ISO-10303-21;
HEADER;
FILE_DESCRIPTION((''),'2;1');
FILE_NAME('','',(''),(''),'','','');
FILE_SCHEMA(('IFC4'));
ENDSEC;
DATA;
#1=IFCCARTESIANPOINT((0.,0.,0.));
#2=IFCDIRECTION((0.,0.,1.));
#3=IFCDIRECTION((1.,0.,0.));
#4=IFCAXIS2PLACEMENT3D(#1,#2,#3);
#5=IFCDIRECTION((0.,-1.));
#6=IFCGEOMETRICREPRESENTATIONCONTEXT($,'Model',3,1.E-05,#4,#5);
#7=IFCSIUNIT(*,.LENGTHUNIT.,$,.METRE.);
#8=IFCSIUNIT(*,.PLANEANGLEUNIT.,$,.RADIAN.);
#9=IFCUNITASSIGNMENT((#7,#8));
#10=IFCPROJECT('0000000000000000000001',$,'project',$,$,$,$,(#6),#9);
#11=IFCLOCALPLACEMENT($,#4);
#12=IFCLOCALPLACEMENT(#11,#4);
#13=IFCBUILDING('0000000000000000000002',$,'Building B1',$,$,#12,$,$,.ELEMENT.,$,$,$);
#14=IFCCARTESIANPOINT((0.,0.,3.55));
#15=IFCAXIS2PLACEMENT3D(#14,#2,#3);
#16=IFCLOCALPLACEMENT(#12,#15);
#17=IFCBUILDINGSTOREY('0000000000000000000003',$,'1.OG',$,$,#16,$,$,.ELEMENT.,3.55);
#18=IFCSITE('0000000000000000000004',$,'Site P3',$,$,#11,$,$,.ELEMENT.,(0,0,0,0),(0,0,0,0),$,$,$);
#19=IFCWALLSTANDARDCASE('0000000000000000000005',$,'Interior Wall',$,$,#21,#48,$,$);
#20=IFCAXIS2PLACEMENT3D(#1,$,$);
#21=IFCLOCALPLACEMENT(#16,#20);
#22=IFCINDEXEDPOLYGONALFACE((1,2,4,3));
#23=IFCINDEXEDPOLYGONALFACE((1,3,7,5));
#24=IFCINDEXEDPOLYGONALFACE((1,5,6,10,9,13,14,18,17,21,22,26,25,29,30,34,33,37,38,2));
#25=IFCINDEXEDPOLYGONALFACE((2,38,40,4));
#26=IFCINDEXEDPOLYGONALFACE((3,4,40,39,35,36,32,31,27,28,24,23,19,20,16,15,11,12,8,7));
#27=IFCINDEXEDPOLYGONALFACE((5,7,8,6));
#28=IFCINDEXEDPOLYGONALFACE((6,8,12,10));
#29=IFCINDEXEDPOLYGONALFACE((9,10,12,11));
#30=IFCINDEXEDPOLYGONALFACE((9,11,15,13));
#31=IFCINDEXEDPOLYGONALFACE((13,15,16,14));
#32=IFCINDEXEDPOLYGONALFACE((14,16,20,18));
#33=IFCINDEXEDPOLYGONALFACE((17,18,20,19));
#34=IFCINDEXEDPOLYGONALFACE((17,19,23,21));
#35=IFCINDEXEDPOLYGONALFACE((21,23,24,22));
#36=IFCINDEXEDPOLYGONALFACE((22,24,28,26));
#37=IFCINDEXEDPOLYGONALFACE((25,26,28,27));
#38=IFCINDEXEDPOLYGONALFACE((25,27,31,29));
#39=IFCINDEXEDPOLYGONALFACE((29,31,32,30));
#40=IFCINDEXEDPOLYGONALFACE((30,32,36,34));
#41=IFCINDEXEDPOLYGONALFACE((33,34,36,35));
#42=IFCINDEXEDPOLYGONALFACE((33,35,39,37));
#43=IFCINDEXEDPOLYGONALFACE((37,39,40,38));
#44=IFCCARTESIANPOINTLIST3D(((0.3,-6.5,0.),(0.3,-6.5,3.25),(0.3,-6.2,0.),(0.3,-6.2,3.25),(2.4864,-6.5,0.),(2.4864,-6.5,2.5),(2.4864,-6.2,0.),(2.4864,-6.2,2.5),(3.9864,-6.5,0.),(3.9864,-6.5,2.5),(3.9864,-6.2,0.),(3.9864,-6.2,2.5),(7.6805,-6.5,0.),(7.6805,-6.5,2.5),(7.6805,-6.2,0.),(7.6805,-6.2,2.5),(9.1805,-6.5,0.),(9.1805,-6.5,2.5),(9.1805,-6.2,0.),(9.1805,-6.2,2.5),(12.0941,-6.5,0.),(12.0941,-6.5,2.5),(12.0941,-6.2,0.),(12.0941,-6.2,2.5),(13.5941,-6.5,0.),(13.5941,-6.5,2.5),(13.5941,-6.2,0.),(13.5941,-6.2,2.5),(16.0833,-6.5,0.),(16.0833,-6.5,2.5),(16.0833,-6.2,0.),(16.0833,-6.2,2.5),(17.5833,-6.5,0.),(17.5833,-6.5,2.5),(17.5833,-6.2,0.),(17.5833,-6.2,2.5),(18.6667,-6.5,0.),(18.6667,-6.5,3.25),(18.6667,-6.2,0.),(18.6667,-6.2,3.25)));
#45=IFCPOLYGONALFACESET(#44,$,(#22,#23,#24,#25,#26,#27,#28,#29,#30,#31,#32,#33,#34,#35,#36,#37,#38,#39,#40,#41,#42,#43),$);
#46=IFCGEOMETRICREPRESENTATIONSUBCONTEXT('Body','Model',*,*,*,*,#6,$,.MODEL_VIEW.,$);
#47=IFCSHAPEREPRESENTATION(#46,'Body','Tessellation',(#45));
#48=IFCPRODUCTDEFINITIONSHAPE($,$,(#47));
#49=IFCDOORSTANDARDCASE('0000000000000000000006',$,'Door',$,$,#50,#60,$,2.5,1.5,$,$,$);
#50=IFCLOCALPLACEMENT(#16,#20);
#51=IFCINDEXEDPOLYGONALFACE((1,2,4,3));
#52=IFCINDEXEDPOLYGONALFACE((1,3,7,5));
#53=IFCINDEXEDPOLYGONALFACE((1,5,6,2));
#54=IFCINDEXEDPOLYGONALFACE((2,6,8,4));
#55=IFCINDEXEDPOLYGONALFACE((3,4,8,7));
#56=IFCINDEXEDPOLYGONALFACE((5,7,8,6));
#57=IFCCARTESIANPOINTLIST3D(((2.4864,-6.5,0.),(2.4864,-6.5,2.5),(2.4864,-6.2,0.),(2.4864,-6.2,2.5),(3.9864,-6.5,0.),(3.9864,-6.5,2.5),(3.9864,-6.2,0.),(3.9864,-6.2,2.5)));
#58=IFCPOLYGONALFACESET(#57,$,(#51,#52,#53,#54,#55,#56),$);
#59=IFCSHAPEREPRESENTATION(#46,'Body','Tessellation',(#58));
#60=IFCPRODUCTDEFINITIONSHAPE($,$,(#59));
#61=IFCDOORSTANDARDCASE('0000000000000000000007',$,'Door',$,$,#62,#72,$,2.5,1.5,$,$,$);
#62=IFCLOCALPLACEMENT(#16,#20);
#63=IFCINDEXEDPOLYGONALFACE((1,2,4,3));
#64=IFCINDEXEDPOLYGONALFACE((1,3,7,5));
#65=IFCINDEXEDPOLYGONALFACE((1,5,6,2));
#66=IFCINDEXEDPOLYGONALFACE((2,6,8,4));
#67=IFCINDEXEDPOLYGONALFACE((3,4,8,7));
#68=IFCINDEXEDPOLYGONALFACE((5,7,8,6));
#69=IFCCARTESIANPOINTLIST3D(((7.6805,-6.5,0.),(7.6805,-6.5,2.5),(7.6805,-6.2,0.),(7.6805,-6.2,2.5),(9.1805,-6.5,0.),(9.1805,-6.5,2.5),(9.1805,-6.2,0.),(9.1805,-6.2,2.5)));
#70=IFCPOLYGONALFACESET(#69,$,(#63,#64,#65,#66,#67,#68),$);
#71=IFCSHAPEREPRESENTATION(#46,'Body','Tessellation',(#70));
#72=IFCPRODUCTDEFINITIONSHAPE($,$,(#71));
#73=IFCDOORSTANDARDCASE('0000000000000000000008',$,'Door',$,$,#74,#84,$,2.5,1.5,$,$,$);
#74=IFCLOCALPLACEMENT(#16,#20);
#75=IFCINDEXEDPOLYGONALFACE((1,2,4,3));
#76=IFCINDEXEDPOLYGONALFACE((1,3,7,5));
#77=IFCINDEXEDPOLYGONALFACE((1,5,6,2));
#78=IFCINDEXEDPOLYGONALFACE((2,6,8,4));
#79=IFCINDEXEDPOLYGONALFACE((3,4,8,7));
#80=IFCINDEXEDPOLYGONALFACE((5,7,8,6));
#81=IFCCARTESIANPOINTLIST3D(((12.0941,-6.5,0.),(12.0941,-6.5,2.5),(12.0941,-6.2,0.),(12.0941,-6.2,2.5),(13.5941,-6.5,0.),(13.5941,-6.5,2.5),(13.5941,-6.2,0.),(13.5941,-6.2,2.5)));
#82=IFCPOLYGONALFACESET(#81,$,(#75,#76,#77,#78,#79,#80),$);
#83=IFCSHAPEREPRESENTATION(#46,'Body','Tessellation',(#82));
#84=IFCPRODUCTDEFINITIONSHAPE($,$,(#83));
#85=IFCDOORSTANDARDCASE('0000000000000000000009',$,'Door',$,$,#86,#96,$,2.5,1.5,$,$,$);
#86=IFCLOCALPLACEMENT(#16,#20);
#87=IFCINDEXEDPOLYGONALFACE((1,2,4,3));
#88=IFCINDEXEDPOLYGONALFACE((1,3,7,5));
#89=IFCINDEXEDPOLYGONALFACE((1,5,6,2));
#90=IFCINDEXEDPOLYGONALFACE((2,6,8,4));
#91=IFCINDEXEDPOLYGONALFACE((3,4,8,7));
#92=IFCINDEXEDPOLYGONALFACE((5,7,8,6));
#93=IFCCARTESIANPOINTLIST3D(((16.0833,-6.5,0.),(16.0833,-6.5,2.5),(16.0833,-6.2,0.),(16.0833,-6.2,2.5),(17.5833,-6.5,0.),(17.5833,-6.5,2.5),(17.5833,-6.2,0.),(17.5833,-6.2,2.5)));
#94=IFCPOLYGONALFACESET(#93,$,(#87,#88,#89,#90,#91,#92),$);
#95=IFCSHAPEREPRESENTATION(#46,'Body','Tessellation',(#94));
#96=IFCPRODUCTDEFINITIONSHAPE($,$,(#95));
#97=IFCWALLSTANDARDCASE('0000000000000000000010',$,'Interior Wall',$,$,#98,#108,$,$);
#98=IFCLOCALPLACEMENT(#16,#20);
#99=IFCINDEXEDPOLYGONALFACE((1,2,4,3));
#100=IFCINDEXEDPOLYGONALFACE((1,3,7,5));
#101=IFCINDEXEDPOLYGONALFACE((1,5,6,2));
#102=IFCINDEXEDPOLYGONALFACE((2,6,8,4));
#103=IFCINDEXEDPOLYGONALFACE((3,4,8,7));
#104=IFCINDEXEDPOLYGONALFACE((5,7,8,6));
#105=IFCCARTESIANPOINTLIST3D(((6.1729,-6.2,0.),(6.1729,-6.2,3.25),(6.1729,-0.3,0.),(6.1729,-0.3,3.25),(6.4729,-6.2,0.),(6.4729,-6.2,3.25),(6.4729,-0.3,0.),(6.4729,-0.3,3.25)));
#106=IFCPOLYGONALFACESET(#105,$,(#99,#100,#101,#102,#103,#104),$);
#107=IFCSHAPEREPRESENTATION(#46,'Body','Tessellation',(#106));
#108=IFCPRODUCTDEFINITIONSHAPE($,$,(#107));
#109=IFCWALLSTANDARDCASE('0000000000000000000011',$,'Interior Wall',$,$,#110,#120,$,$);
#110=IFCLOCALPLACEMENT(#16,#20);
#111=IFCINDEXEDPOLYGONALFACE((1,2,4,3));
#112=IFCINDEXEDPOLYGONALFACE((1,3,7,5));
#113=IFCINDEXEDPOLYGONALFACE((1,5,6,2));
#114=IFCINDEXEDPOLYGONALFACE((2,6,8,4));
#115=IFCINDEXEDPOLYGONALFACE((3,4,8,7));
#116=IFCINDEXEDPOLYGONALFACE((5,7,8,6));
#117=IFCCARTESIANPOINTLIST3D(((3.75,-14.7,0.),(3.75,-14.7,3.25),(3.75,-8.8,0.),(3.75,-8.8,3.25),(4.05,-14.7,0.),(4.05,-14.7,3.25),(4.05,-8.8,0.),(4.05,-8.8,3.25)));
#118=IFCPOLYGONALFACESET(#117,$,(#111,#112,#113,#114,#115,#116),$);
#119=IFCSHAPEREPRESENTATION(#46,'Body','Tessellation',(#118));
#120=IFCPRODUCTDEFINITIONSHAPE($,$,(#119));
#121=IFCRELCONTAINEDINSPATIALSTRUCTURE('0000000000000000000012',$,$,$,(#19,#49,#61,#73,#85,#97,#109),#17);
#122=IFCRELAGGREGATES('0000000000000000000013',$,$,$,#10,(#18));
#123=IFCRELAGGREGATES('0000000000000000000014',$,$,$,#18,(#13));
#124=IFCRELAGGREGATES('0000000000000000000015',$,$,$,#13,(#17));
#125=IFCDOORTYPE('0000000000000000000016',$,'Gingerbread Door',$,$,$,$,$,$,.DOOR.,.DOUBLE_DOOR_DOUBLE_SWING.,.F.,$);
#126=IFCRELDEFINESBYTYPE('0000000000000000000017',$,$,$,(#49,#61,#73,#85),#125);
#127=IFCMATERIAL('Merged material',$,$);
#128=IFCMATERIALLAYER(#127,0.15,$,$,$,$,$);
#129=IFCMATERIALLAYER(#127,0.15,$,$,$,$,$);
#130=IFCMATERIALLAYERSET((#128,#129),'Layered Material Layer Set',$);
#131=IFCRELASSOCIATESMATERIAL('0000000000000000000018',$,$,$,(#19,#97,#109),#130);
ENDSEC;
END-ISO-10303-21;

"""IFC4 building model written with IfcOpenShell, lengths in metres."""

from ifc_helpers import new_model, si_unit, direction, frame, origin_with_axes, place, context, subcontext, project, spatial, polyline, outline, extrude, source, transform, mapped, material, layer, layer_set, layer_usage, type_object, element, fill, save


model = new_model("IFC4")

# Units and contexts
model_context = context("Model", 3, precision=1e-05, world=origin_with_axes(), true_north=direction((0.0, -1.0)))
body_context = subcontext(model_context, "Body", "Model", "MODEL_VIEW")
ifc_project = project(units=[si_unit("LENGTHUNIT", "METRE"), si_unit("PLANEANGLEUNIT", "RADIAN")], contexts=[model_context])

# Site, building, storey
site_placement = place(None, origin_with_axes())
site = spatial("IfcSite", under=ifc_project, at=site_placement, Name="Site P3", CompositionType="ELEMENT", RefLatitude=(0, 0, 0, 0), RefLongitude=(0, 0, 0, 0))
building_placement = place(site_placement, origin_with_axes())
building = spatial("IfcBuilding", under=site, at=building_placement, Name="Building B1", CompositionType="ELEMENT")
storey_placement = place(building_placement, frame((0.0, 0.0, 3.55), z_axis=(0.0, 0.0, 1.0), x_axis=(1.0, 0.0, 0.0)))
storey = spatial("IfcBuildingStorey", under=building, at=storey_placement, Name="1.OG", CompositionType="ELEMENT", Elevation=3.55)

# Shared definitions
ifc_material = material(Name="Merged material")

# Wall, openings, doors
ifc_layer_1 = layer(ifc_material, 0.15)
ifc_layer_2 = layer(ifc_material, 0.15)
ifc_layer_set_1 = layer_set([ifc_layer_1, ifc_layer_2], Name="Layered Material Layer Set")
ifc_layer_usage_1 = layer_usage(ifc_layer_set_1, "AXIS2", "POSITIVE", -0.15)
door_type = type_object("IfcDoorType", Name="Gingerbread Door", OperationType="DOUBLE_DOOR_DOUBLE_SWING", ParameterTakesPrecedence=False, PredefinedType="DOOR")
shared_shape_1 = source(origin_with_axes(), body_context, "Body", "SweptSolid", [
    extrude(outline(polyline([(0.0, 0.0), (0.0, 1.5), (2.5, 1.5), (2.5, 0.0), (0.0, 0.0)])), frame((0.0, -0.15, 0.0), z_axis=(0.0, 1.0, 0.0), x_axis=(0.0, 0.0, 1.0)), (0.0, 0.0, 1.0), 0.3),
])
wall_1_placement = place(storey_placement, frame((0.3, -6.35, 0.0), z_axis=(0.0, 0.0, 1.0), x_axis=(1.0, 0.0, 0.0)))
wall_1 = element("IfcWallStandardCase", 1, at=wall_1_placement, inside=storey, material=ifc_layer_usage_1, Name="Interior Wall", context=body_context, shape_type="SweptSolid", body=[
    extrude(outline(polyline([(0.0, 0.15), (18.3667, 0.15), (18.3667, -0.15), (0.0, -0.15), (0.0, 0.15)])), origin_with_axes(), (0.0, 0.0, 1.0), 3.25),
])
opening_1_placement = place(wall_1_placement, frame((2.1864, 0.0, 0.0), z_axis=(0.0, 0.0, 1.0), x_axis=(1.0, 0.0, 0.0)))
opening_1 = element("IfcOpeningStandardCase", 2, at=opening_1_placement, cuts=wall_1, context=body_context, shape_type="SweptSolid", body=[
    extrude(outline(polyline([(0.0, 0.0), (0.0, 1.5), (2.5, 1.5), (2.5, 0.0), (0.0, 0.0)])), frame((0.0, -0.15, 0.0), z_axis=(0.0, 1.0, 0.0), x_axis=(0.0, 0.0, 1.0)), (0.0, 0.0, 1.0), 0.3),
])
opening_2_placement = place(wall_1_placement, frame((7.3805, 0.0, 0.0), z_axis=(0.0, 0.0, 1.0), x_axis=(1.0, 0.0, 0.0)))
opening_2 = element("IfcOpeningStandardCase", 3, at=opening_2_placement, cuts=wall_1, context=body_context, shape_type="SweptSolid", body=[
    extrude(outline(polyline([(0.0, 0.0), (0.0, 1.5), (2.5, 1.5), (2.5, 0.0), (0.0, 0.0)])), frame((0.0, -0.15, 0.0), z_axis=(0.0, 1.0, 0.0), x_axis=(0.0, 0.0, 1.0)), (0.0, 0.0, 1.0), 0.3),
])
opening_3_placement = place(wall_1_placement, frame((11.7941, 0.0, 0.0), z_axis=(0.0, 0.0, 1.0), x_axis=(1.0, 0.0, 0.0)))
opening_3 = element("IfcOpeningStandardCase", 4, at=opening_3_placement, cuts=wall_1, context=body_context, shape_type="SweptSolid", body=[
    extrude(outline(polyline([(0.0, 0.0), (0.0, 1.5), (2.5, 1.5), (2.5, 0.0), (0.0, 0.0)])), frame((0.0, -0.15, 0.0), z_axis=(0.0, 1.0, 0.0), x_axis=(0.0, 0.0, 1.0)), (0.0, 0.0, 1.0), 0.3),
])
opening_4_placement = place(wall_1_placement, frame((15.7833, 0.0, 0.0), z_axis=(0.0, 0.0, 1.0), x_axis=(1.0, 0.0, 0.0)))
opening_4 = element("IfcOpeningStandardCase", 5, at=opening_4_placement, cuts=wall_1, context=body_context, shape_type="SweptSolid", body=[
    extrude(outline(polyline([(0.0, 0.0), (0.0, 1.5), (2.5, 1.5), (2.5, 0.0), (0.0, 0.0)])), frame((0.0, -0.15, 0.0), z_axis=(0.0, 1.0, 0.0), x_axis=(0.0, 0.0, 1.0)), (0.0, 0.0, 1.0), 0.3),
])
door_1_placement = place(opening_1_placement, origin_with_axes())
door_1 = element("IfcDoorStandardCase", 6, at=door_1_placement, inside=storey, type_object=door_type, Name="Door", OverallHeight=2.5, OverallWidth=1.5, context=body_context, shape_type="MappedRepresentation", body=[
    mapped(shared_shape_1, transform((0.0, 0.0, 0.0))),
])
fill(opening_1, door_1)
door_2_placement = place(opening_2_placement, origin_with_axes())
door_2 = element("IfcDoorStandardCase", 7, at=door_2_placement, inside=storey, type_object=door_type, Name="Door", OverallHeight=2.5, OverallWidth=1.5, context=body_context, shape_type="MappedRepresentation", body=[
    mapped(shared_shape_1, transform((0.0, 0.0, 0.0))),
])
fill(opening_2, door_2)
door_3_placement = place(opening_3_placement, origin_with_axes())
door_3 = element("IfcDoorStandardCase", 8, at=door_3_placement, inside=storey, type_object=door_type, Name="Door", OverallHeight=2.5, OverallWidth=1.5, context=body_context, shape_type="MappedRepresentation", body=[
    mapped(shared_shape_1, transform((0.0, 0.0, 0.0))),
])
fill(opening_3, door_3)
door_4_placement = place(opening_4_placement, origin_with_axes())
door_4 = element("IfcDoorStandardCase", 9, at=door_4_placement, inside=storey, type_object=door_type, Name="Door", OverallHeight=2.5, OverallWidth=1.5, context=body_context, shape_type="MappedRepresentation", body=[
    mapped(shared_shape_1, transform((0.0, 0.0, 0.0))),
])
fill(opening_4, door_4)

# Walls
for number, where, z_axis, x_axis, name in (
    (10, (6.3229, -0.3, 0.0), (0.0, 0.0, 1.0), (0.0, -1.0, 0.0), "Interior Wall"),
    (11, (3.9, -8.8, 0.0), (0.0, 0.0, 1.0), (0.0, -1.0, 0.0), "Interior Wall"),
):
    element("IfcWallStandardCase", number, at=place(storey_placement, frame(where, z_axis=z_axis, x_axis=x_axis)), inside=storey, material=ifc_layer_usage_1, Name=name, context=body_context, shape_type="SweptSolid", body=[
        extrude(outline(polyline([(0.0, 0.15), (5.9, 0.15), (5.9, -0.15), (0.0, -0.15), (0.0, 0.15)])), origin_with_axes(), (0.0, 0.0, 1.0), 3.25),
    ])

save(model, "model.ifc")
